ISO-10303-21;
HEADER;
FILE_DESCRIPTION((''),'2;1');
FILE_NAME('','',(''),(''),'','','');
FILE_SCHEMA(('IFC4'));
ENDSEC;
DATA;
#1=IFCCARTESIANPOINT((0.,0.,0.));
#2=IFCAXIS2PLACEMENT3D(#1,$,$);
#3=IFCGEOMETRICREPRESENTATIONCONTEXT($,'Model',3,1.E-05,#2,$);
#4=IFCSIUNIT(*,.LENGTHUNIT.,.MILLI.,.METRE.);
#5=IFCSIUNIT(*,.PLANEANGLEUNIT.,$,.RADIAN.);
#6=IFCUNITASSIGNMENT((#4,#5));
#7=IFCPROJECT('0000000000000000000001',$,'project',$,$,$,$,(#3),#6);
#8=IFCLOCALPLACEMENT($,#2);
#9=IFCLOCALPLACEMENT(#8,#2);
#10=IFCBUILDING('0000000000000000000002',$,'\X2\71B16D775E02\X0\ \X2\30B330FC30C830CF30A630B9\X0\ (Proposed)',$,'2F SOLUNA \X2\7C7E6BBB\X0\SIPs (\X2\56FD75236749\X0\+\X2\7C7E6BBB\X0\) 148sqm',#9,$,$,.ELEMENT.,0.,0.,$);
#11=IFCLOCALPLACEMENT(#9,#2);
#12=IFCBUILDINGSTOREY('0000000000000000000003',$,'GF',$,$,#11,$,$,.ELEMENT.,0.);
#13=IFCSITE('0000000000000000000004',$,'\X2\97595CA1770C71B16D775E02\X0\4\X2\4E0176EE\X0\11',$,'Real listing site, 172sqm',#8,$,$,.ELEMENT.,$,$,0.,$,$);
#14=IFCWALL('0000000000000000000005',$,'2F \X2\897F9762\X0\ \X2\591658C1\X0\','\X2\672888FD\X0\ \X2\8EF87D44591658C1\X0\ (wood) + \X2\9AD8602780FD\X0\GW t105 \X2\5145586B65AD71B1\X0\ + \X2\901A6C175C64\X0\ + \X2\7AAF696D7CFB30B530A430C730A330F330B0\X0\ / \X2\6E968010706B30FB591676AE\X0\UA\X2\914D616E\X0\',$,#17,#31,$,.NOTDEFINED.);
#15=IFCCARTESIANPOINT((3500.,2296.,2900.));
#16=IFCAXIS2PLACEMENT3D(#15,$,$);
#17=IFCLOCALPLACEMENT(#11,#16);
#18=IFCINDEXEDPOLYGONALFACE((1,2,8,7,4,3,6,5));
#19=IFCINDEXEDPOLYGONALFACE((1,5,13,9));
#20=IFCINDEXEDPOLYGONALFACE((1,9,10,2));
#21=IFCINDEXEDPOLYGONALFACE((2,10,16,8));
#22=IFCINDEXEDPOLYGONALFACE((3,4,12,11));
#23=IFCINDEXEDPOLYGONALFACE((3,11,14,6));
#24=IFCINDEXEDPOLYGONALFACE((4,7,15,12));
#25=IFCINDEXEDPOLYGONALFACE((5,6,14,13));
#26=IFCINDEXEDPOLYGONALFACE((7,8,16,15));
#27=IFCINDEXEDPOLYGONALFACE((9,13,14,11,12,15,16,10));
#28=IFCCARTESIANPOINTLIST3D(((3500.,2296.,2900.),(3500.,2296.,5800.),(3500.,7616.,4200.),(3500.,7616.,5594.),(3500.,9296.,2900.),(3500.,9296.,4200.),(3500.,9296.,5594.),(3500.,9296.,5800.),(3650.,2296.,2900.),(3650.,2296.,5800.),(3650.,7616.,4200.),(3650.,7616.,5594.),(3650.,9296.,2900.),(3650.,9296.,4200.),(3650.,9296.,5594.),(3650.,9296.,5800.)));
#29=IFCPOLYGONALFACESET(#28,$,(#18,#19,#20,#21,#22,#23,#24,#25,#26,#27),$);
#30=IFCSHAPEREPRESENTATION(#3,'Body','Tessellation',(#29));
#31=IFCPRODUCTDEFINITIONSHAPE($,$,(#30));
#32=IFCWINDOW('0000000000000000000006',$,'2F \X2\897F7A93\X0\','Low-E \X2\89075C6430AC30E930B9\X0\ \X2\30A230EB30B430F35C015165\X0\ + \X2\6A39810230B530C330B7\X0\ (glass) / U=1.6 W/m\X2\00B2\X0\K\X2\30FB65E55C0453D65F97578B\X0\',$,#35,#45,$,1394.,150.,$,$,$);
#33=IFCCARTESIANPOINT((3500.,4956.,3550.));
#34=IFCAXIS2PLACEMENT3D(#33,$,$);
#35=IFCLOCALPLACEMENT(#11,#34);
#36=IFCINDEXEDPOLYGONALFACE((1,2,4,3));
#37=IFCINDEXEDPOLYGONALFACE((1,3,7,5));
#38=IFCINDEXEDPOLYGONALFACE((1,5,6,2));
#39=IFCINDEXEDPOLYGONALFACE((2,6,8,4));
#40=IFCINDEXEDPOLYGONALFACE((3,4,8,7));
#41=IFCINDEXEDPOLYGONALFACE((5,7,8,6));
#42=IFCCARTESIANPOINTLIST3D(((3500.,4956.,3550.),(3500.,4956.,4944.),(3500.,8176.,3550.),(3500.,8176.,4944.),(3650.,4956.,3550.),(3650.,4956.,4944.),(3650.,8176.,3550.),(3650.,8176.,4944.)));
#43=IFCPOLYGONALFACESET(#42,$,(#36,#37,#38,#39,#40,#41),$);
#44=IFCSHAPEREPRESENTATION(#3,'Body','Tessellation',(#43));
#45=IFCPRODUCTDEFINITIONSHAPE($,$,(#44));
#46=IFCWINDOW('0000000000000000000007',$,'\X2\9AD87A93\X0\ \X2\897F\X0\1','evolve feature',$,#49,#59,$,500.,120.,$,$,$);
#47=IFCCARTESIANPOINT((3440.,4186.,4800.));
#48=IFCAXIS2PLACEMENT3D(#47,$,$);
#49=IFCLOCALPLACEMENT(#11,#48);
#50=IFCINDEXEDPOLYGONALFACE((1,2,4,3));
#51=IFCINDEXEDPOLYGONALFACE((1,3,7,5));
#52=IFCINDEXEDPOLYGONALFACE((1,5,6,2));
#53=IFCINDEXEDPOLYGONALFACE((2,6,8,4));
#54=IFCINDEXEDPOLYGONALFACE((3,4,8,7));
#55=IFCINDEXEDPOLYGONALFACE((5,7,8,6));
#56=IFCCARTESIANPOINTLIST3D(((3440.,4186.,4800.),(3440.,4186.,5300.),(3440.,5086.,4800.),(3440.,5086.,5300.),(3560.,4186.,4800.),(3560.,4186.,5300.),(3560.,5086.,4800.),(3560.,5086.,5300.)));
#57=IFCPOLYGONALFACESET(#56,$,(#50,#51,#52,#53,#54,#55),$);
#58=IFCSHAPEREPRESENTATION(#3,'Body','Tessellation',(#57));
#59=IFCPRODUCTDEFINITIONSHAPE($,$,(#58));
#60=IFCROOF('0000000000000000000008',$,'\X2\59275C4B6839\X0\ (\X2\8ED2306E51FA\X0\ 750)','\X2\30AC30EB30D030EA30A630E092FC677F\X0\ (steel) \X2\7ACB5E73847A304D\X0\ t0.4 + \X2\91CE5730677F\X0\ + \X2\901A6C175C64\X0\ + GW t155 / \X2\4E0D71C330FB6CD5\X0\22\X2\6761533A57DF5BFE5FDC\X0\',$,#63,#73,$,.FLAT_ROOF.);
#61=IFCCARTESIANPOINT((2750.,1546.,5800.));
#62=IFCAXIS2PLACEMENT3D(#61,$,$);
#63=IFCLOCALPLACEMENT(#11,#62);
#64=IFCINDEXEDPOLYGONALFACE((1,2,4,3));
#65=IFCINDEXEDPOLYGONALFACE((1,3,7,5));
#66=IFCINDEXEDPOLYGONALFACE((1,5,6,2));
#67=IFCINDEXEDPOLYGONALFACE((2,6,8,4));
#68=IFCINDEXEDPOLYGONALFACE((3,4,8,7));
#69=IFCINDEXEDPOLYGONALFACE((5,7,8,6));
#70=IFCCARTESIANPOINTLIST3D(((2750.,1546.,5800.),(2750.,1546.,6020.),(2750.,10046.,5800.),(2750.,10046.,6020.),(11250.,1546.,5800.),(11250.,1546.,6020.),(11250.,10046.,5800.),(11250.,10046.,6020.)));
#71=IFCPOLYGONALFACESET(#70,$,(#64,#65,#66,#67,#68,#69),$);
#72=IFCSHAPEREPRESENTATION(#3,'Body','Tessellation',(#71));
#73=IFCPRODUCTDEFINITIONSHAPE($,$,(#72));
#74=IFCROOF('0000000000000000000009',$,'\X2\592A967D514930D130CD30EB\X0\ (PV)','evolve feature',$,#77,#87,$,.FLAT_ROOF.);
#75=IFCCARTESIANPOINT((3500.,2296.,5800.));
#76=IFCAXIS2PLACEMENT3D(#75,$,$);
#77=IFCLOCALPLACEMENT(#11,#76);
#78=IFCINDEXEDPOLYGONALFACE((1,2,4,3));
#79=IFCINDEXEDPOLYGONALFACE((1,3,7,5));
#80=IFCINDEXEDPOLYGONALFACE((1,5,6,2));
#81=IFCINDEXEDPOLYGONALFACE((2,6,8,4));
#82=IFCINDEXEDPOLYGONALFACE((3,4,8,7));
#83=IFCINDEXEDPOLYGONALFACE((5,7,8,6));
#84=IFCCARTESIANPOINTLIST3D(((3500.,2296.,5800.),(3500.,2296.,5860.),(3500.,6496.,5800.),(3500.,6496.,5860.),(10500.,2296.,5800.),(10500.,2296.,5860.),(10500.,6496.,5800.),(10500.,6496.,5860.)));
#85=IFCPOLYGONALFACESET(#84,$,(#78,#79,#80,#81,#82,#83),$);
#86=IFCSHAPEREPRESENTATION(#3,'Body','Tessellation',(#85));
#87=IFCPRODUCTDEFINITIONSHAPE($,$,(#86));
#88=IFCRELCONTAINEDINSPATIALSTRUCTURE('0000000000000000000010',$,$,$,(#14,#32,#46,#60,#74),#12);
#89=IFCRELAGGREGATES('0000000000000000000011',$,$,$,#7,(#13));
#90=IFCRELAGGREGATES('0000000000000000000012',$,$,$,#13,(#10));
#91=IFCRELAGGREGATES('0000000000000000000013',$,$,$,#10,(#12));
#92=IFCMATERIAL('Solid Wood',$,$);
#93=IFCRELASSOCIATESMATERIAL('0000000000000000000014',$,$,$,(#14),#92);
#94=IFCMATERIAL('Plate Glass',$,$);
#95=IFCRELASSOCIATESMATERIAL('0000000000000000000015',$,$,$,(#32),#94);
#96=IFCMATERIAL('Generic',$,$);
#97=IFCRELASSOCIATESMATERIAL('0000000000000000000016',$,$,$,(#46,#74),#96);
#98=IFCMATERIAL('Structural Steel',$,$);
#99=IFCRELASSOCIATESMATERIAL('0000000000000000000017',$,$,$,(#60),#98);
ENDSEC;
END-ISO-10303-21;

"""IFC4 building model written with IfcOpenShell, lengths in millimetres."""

from ifc_helpers import new_model, si_unit, frame, frame_2d, origin, place, context, project, spatial, rectangle, extrude, material, element, fill, save


model = new_model("IFC4")

# Units and contexts
model_context = context("Model", 3, precision=1e-05, world=origin())
ifc_project = project(units=[si_unit("LENGTHUNIT", "METRE", prefix="MILLI"), si_unit("PLANEANGLEUNIT", "RADIAN")], contexts=[model_context])

# Site, building, storey
site_placement = place(None, origin())
site = spatial("IfcSite", under=ifc_project, at=site_placement, Name="静岡県熱海市4丁目11", ObjectType="Real listing site, 172sqm", CompositionType="ELEMENT", RefElevation=0.0)
building_placement = place(site_placement, origin())
building = spatial("IfcBuilding", under=site, at=building_placement, Name="熱海市 コートハウス (Proposed)", ObjectType="2F SOLUNA 籾殻SIPs (国産杉+籾殻) 148sqm", CompositionType="ELEMENT", ElevationOfRefHeight=0.0, ElevationOfTerrain=0.0)
storey_placement = place(building_placement, origin())
storey = spatial("IfcBuildingStorey", under=building, at=storey_placement, Name="GF", CompositionType="ELEMENT", Elevation=0.0)

# Shared definitions
ifc_material_1 = material(Name="Solid Wood")
ifc_material_2 = material(Name="Generic")

# Shared definitions
ifc_material_3 = material(Name="Plate Glass")

# Wall, openings, windows
wall_1_placement = place(storey_placement, frame((3500.0, 2296.0, 2900.0)))
wall_1 = element("IfcWall", 1, at=wall_1_placement, inside=storey, material=ifc_material_1, Name="2F 西面 外壁", Description="木製 軸組外壁 (wood) + 高性能GW t105 充填断熱 + 通気層 + 窯業系サイディング / 準耐火・外皮UA配慮", PredefinedType="NOTDEFINED", context=model_context, shape_type="SweptSolid", body=[
    extrude(rectangle(XDim=150.0, YDim=7000.0, at=frame_2d((75.0, 3500.0))), frame((3500.0, 2296.0, 2900.0)), (0.0, 0.0, 1.0), 2900.0),
])
opening_1_placement = place(storey_placement, frame((3500.0, 4956.0, 3550.0)))
opening_1 = element("IfcOpeningElement", 2, at=opening_1_placement, cuts=wall_1, PredefinedType="NOTDEFINED", context=model_context, shape_type="SweptSolid", body=[
    extrude(rectangle(XDim=150.0, YDim=3220.0, at=frame_2d((75.0, 1610.0))), frame((3500.0, 4956.0, 3550.0)), (0.0, 0.0, 1.0), 1394.0),
])
opening_2_placement = place(storey_placement, frame((3440.0, 4186.0, 4800.0)))
opening_2 = element("IfcOpeningElement", 3, at=opening_2_placement, cuts=wall_1, PredefinedType="NOTDEFINED", context=model_context, shape_type="SweptSolid", body=[
    extrude(rectangle(XDim=120.0, YDim=900.0, at=frame_2d((60.0, 450.0))), frame((3440.0, 4186.0, 4800.0)), (0.0, 0.0, 1.0), 500.0),
])
window_1_placement = place(storey_placement, frame((3500.0, 4956.0, 3550.0)))
window_1 = element("IfcWindow", 4, at=window_1_placement, inside=storey, material=ifc_material_3, Name="2F 西窓", Description="Low-E 複層ガラス アルゴン封入 + 樹脂サッシ (glass) / U=1.6 W/m²K・日射取得型", OverallHeight=1394.0, OverallWidth=150.0, context=model_context, shape_type="SweptSolid", body=[
    extrude(rectangle(XDim=150.0, YDim=3220.0, at=frame_2d((75.0, 1610.0))), frame((3500.0, 4956.0, 3550.0)), (0.0, 0.0, 1.0), 1394.0),
])
fill(opening_1, window_1)
window_2_placement = place(storey_placement, frame((3440.0, 4186.0, 4800.0)))
window_2 = element("IfcWindow", 5, at=window_2_placement, inside=storey, material=ifc_material_2, Name="高窓 西1", Description="evolve feature", OverallHeight=500.0, OverallWidth=120.0, context=model_context, shape_type="SweptSolid", body=[
    extrude(rectangle(XDim=120.0, YDim=900.0, at=frame_2d((60.0, 450.0))), frame((3440.0, 4186.0, 4800.0)), (0.0, 0.0, 1.0), 500.0),
])
fill(opening_2, window_2)

# Roofs
ifc_material_4 = material(Name="Structural Steel")
roof_1_placement = place(storey_placement, frame((2750.0, 1546.0, 5800.0)))
element("IfcRoof", 6, at=roof_1_placement, inside=storey, material=ifc_material_4, Name="大屋根 (軒の出 750)", Description="ガルバリウム鋼板 (steel) 立平葺き t0.4 + 野地板 + 通気層 + GW t155 / 不燃・法22条区域対応", PredefinedType="FLAT_ROOF", context=model_context, shape_type="SweptSolid", body=[
    extrude(rectangle(XDim=8500.0, YDim=8500.0, at=frame_2d((4250.0, 4250.0))), frame((2750.0, 1546.0, 5800.0)), (0.0, 0.0, 1.0), 220.0),
])
roof_2_placement = place(storey_placement, frame((3500.0, 2296.0, 5800.0)))
element("IfcRoof", 7, at=roof_2_placement, inside=storey, material=ifc_material_2, Name="太陽光パネル (PV)", Description="evolve feature", PredefinedType="FLAT_ROOF", context=model_context, shape_type="SweptSolid", body=[
    extrude(rectangle(XDim=7000.0, YDim=4200.0, at=frame_2d((3500.0, 2100.0))), frame((3500.0, 2296.0, 5800.0)), (0.0, 0.0, 1.0), 60.0),
])

save(model, "model.ifc")
